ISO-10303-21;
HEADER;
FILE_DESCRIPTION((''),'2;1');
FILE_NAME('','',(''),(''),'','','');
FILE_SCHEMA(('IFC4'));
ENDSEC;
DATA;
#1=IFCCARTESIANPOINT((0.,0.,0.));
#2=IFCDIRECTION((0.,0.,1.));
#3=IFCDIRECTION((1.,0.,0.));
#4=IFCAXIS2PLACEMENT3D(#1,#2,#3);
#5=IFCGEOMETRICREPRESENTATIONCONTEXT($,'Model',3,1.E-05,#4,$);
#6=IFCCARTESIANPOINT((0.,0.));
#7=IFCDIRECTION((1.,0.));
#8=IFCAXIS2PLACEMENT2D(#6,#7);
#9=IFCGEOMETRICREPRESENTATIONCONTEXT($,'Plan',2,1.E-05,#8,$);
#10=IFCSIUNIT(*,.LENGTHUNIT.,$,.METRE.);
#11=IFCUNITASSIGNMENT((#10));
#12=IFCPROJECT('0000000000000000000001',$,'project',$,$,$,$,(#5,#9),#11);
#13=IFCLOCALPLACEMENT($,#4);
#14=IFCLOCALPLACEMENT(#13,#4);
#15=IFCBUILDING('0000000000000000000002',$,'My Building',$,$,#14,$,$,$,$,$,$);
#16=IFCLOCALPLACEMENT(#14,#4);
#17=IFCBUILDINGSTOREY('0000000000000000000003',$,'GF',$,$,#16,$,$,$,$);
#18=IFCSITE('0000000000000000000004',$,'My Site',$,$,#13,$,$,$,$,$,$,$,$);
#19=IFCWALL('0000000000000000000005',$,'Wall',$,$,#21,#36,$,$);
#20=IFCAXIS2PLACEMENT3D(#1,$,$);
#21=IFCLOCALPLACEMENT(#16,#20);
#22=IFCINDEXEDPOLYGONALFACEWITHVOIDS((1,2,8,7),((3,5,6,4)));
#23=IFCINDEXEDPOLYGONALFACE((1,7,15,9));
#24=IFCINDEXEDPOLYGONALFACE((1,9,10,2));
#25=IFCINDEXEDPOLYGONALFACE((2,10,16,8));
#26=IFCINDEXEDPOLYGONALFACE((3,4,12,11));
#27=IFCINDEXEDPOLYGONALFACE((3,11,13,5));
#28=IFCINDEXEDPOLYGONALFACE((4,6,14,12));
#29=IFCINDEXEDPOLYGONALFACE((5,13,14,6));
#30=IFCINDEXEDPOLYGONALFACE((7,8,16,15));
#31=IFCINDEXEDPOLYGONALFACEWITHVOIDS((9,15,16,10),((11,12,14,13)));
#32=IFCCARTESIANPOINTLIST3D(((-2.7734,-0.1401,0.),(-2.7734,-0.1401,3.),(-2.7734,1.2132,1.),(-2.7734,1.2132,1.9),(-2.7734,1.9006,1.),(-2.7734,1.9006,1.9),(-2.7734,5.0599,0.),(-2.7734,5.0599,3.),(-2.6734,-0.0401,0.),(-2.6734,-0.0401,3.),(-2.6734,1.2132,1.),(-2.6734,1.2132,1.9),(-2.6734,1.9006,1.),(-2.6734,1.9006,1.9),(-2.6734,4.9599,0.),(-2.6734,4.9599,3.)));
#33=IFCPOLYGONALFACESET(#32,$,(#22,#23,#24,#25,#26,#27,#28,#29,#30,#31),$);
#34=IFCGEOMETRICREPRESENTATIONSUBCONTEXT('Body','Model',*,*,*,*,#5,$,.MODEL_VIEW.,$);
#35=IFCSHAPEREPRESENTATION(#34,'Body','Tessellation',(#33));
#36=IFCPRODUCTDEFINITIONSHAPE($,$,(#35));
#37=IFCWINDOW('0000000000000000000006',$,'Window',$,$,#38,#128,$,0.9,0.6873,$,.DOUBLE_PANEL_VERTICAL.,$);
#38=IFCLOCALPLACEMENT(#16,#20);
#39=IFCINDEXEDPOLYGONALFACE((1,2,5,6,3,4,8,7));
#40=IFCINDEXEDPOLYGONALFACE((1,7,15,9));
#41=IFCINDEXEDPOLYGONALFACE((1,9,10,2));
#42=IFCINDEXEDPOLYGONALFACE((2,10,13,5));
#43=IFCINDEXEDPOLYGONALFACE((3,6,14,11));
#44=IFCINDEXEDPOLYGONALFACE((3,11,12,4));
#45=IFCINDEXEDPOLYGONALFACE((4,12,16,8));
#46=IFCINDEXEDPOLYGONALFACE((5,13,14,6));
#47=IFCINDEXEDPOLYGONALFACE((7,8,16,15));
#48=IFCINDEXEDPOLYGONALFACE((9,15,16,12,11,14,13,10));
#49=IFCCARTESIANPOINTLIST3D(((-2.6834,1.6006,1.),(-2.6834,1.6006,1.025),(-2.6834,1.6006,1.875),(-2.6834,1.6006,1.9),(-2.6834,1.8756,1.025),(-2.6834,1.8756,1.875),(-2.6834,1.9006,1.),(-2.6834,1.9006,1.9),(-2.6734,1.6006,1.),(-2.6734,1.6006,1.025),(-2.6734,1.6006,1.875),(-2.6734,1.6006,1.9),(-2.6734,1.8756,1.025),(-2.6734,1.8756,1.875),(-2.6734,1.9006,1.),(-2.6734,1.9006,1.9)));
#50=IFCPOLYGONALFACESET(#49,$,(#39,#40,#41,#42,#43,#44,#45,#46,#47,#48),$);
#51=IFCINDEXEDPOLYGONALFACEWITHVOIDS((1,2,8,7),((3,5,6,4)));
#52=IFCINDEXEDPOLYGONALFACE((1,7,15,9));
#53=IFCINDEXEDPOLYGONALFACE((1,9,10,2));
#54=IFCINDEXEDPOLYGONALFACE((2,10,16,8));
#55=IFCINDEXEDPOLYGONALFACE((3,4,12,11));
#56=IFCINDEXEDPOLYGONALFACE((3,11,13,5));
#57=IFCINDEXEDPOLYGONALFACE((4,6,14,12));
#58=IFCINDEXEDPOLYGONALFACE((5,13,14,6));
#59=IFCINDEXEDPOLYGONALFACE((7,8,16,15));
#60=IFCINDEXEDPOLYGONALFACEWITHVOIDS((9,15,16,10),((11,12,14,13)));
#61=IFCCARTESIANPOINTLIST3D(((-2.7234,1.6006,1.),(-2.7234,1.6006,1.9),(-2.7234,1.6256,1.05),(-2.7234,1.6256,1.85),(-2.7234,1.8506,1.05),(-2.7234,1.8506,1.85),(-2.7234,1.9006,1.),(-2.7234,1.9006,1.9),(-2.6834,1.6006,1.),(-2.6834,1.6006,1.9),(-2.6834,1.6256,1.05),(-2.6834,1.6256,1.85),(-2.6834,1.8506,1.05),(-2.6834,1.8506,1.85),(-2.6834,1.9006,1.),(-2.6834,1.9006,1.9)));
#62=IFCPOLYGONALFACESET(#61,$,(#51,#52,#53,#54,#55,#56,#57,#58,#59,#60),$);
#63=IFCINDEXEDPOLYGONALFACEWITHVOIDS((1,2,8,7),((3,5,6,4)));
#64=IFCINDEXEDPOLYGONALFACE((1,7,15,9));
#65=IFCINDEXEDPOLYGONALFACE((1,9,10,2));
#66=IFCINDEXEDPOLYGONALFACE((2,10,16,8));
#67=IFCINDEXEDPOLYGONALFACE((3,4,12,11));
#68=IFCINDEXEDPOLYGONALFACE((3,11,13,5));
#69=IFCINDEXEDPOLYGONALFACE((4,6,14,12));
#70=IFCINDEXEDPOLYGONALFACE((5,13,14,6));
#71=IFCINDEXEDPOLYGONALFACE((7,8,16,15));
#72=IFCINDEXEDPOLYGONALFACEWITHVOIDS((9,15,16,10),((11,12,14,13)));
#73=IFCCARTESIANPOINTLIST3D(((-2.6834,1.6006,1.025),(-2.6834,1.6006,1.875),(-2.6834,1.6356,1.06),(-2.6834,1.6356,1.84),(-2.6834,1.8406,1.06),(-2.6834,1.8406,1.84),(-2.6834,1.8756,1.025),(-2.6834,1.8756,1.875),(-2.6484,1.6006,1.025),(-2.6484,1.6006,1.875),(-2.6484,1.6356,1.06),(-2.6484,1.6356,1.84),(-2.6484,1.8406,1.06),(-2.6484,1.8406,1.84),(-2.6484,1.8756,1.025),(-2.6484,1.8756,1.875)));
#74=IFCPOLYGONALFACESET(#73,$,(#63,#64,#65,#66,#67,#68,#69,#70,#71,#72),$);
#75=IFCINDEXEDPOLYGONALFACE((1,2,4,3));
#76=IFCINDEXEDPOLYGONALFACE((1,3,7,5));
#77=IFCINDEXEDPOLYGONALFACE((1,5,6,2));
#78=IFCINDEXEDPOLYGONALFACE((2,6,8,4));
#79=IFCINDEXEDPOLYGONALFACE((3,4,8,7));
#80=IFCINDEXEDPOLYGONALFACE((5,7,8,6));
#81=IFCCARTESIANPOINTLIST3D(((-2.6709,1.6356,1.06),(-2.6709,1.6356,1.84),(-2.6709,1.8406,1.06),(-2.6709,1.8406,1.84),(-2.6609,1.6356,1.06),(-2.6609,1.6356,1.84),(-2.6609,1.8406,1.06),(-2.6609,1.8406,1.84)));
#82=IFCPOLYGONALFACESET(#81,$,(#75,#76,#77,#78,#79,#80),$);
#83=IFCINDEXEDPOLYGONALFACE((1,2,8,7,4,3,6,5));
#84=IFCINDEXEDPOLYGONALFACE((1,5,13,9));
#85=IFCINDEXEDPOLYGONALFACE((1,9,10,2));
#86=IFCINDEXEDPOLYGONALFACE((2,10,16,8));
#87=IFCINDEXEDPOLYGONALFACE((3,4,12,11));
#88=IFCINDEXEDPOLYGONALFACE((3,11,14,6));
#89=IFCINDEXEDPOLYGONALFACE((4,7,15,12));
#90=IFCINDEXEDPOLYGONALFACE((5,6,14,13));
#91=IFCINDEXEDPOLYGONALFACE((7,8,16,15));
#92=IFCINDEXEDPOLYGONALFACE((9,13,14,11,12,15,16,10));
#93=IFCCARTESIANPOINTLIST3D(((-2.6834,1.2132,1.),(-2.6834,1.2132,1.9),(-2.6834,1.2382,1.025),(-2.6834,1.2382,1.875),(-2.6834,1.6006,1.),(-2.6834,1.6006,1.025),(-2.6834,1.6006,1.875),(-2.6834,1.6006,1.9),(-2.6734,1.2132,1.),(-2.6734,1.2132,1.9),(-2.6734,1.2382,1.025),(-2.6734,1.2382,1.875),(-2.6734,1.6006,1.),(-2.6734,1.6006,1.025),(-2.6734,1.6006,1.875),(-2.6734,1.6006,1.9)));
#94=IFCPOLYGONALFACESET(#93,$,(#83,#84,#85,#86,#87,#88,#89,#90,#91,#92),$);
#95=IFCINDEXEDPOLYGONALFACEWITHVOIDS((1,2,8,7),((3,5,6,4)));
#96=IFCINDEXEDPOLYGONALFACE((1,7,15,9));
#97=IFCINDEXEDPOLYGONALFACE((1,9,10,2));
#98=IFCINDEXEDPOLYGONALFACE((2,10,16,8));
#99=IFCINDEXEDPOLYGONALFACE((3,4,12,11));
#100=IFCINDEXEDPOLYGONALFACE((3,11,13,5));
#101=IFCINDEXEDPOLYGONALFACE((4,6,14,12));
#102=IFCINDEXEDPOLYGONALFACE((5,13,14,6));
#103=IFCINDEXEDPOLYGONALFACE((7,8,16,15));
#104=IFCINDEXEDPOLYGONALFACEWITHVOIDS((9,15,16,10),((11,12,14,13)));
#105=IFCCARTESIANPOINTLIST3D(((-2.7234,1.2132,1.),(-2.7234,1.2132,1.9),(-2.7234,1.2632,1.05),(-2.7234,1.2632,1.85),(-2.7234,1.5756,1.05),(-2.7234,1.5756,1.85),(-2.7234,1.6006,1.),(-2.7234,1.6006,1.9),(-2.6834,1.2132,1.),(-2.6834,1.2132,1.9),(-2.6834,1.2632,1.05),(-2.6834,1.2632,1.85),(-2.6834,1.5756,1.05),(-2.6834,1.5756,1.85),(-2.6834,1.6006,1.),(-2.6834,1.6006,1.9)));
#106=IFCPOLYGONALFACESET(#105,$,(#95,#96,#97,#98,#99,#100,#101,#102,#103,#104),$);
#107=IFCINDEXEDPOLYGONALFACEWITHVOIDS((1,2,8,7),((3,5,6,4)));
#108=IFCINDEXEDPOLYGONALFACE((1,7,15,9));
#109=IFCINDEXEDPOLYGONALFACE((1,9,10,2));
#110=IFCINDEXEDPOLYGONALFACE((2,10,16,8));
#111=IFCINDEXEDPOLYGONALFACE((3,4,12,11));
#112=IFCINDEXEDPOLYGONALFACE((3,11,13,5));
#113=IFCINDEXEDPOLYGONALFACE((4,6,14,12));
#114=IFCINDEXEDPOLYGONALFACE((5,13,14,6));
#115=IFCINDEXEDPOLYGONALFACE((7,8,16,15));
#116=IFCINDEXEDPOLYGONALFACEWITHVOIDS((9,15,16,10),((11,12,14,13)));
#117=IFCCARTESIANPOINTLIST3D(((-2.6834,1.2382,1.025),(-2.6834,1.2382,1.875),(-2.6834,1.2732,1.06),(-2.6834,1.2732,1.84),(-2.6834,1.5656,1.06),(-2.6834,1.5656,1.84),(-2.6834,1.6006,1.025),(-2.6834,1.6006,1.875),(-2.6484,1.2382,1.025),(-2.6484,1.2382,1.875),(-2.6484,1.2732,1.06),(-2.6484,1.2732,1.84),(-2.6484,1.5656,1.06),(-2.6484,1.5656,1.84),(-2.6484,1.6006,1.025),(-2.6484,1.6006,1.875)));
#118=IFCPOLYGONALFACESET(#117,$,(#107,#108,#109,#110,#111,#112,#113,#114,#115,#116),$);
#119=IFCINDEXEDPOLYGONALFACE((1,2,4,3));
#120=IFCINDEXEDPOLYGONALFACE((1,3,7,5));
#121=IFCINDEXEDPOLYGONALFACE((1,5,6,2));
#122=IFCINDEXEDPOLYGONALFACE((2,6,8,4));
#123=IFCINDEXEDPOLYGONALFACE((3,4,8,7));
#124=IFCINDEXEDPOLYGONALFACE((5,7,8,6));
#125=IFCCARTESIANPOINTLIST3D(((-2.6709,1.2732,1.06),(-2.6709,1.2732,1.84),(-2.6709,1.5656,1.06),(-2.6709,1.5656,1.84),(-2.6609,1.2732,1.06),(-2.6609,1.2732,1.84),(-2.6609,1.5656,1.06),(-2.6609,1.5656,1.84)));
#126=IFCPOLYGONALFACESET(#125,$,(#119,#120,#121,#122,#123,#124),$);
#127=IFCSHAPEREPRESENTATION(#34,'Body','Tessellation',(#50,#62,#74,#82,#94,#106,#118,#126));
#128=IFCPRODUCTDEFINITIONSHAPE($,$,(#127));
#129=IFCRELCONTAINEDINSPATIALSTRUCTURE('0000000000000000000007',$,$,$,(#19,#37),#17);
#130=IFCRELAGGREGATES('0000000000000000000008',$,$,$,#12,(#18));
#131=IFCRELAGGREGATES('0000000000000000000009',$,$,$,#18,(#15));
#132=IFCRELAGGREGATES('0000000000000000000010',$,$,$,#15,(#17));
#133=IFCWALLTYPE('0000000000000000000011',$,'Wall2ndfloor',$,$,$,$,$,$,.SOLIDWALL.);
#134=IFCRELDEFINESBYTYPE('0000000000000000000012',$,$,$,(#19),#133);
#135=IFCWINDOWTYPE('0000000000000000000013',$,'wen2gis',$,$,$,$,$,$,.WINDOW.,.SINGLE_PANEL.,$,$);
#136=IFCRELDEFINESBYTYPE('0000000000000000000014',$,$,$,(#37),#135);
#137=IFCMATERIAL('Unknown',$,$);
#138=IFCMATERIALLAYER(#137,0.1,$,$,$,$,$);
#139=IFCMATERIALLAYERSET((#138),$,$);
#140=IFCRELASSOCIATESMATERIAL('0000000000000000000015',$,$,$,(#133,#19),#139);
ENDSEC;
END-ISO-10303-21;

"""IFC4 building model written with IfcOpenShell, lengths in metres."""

from ifc_helpers import new_model, entity, si_unit, frame, origin_with_axes, origin_2d_with_axis, place, context, subcontext, project, spatial, line, indexed_curve, outline, extrude, shape, source, transform, mapped, material, layer, layer_set, layer_usage, type_object, type_shapes, element, fill, save


model = new_model("IFC4")

# Units and contexts
model_context = context("Model", 3, precision=1e-05, world=origin_with_axes())
plan_context = context("Plan", 2, precision=1e-05, world=origin_2d_with_axis())
body_context_1 = subcontext(model_context, "Body", "Model", "MODEL_VIEW")
body_context_2 = subcontext(plan_context, "Body", "Plan", "PLAN_VIEW")
ifc_project = project(units=[si_unit("LENGTHUNIT", "METRE")], contexts=[model_context, plan_context])

# Site, building, storey
site_placement = place(None, origin_with_axes())
site = spatial("IfcSite", under=ifc_project, at=site_placement, Name="My Site")
building_placement = place(site_placement, origin_with_axes())
building = spatial("IfcBuilding", under=site, at=building_placement, Name="My Building")
storey_placement = place(building_placement, origin_with_axes())
storey = spatial("IfcBuildingStorey", under=building, at=storey_placement, Name="GF")

# Shared definitions
ifc_material = material(Name="Unknown")

# Shared definitions
ifc_layer_1 = layer(ifc_material, 0.1)
ifc_layer_set_1 = layer_set([ifc_layer_1])
wall_type = type_object("IfcWallType", Name="Wall2ndfloor", PredefinedType="SOLIDWALL", material=ifc_layer_set_1)

# Wall, opening, window
ifc_layer_usage_1 = layer_usage(ifc_layer_set_1, "AXIS2", "POSITIVE", 0.0)
wall_1_placement = place(storey_placement, frame((-2.7734, 5.0599, 0.0), z_axis=(0.0, 0.0, 1.0), x_axis=(0.0, -1.0, 0.0)))
wall_1 = element("IfcWall", 1, at=wall_1_placement, inside=storey, type_object=wall_type, material=ifc_layer_usage_1, Name="Wall", context=body_context_1, shape_type="SweptSolid", body=[
    extrude(outline(indexed_curve([(0.0, 0.0), (0.1, 0.1), (5.1, 0.1), (5.2, 0.0)], segments=[line(1, 2, 3, 4, 1)])), origin_with_axes(), (0.0, 0.0, 1.0), 3.0),
])
shared_shape_1 = source(origin_with_axes(), body_context_1, "Body", "SweptSolid", [
    extrude(outline(indexed_curve([(0.0, 0.0), (0.6873, 0.0), (0.6873, 0.9), (0.0, 0.9)], segments=[line(1, 2, 3, 4, 1)])), frame((0.0, -0.6, 0.0), z_axis=(0.0, -1.0, 0.0), x_axis=(1.0, 0.0, 0.0)), (0.0, 0.0, -1.0), 1.2),
])
opening_1_placement = place(wall_1_placement, frame((3.1593, 0.0, 1.0), z_axis=(0.0, 0.0, 1.0), x_axis=(1.0, 0.0, 0.0)))
opening_1 = element("IfcOpeningElement", 2, at=opening_1_placement, cuts=wall_1, PredefinedType="OPENING", context=body_context_1, shape_type="MappedRepresentation", body=[
    mapped(shared_shape_1, transform((0.0, 0.0, 0.0), x_axis=(1.0, 0.0, 0.0), y_axis=(0.0, 1.0, 0.0), z_axis=(0.0, 0.0, 1.0), scale=1.0)),
])
window_type_1 = type_object("IfcWindowType", Name="wen2gis", PartitioningType="SINGLE_PANEL", PredefinedType="WINDOW")
shared_shape_2 = source(origin_with_axes(), body_context_1, "Body", "SweptSolid", [
    extrude(outline(indexed_curve([(0.3, 0.0), (0.0, 0.0), (0.0, 0.9), (0.3, 0.9), (0.3, 0.875), (0.025, 0.875), (0.025, 0.025), (0.3, 0.025)], segments=[line(1, 2, 3, 4, 5, 6, 7, 8, 1)])), frame((0.0, 0.09, 0.0), z_axis=(0.0, -1.0, 0.0), x_axis=(1.0, 0.0, 0.0)), (0.0, 0.0, -1.0), 0.01),
    extrude(outline(indexed_curve([(0.0, 0.0), (0.3, 0.0), (0.3, 0.9), (0.0, 0.9)], segments=[line(1, 2, 3, 4, 1)]), holes=[indexed_curve([(0.05, 0.05), (0.275, 0.05), (0.275, 0.85), (0.05, 0.85)], segments=[line(1, 2, 3, 4, 1)])]), frame((0.0, 0.05, 0.0), z_axis=(0.0, -1.0, 0.0), x_axis=(1.0, 0.0, 0.0)), (0.0, 0.0, -1.0), 0.04),
    extrude(outline(indexed_curve([(0.0, 0.0), (0.275, 0.0), (0.275, 0.85), (0.0, 0.85)], segments=[line(1, 2, 3, 4, 1)]), holes=[indexed_curve([(0.035, 0.035), (0.24, 0.035), (0.24, 0.815), (0.035, 0.815)], segments=[line(1, 2, 3, 4, 1)])]), frame((0.025, 0.09, 0.025), z_axis=(0.0, -1.0, 0.0), x_axis=(1.0, 0.0, 0.0)), (0.0, 0.0, -1.0), 0.035),
    extrude(outline(indexed_curve([(0.035, 0.035), (0.24, 0.035), (0.24, 0.815), (0.035, 0.815)], segments=[line(1, 2, 3, 4, 1)])), frame((0.025, 0.1025, 0.025), z_axis=(0.0, -1.0, 0.0), x_axis=(1.0, 0.0, 0.0)), (0.0, 0.0, -1.0), 0.01),
    extrude(outline(indexed_curve([(0.0, 0.9), (0.3873, 0.9), (0.3873, 0.0), (0.0, 0.0), (0.0, 0.025), (0.3623, 0.025), (0.3623, 0.875), (0.0, 0.875)], segments=[line(1, 2, 3, 4, 5, 6, 7, 8, 1)])), frame((0.3, 0.09, 0.0), z_axis=(0.0, -1.0, 0.0), x_axis=(1.0, 0.0, 0.0)), (0.0, 0.0, -1.0), 0.01),
    extrude(outline(indexed_curve([(0.0, 0.0), (0.3873, 0.0), (0.3873, 0.9), (0.0, 0.9)], segments=[line(1, 2, 3, 4, 1)]), holes=[indexed_curve([(0.025, 0.05), (0.3373, 0.05), (0.3373, 0.85), (0.025, 0.85)], segments=[line(1, 2, 3, 4, 1)])]), frame((0.3, 0.05, 0.0), z_axis=(0.0, -1.0, 0.0), x_axis=(1.0, 0.0, 0.0)), (0.0, 0.0, -1.0), 0.04),
    extrude(outline(indexed_curve([(0.0, 0.0), (0.3623, 0.0), (0.3623, 0.85), (0.0, 0.85)], segments=[line(1, 2, 3, 4, 1)]), holes=[indexed_curve([(0.035, 0.035), (0.3273, 0.035), (0.3273, 0.815), (0.035, 0.815)], segments=[line(1, 2, 3, 4, 1)])]), frame((0.3, 0.09, 0.025), z_axis=(0.0, -1.0, 0.0), x_axis=(1.0, 0.0, 0.0)), (0.0, 0.0, -1.0), 0.035),
    extrude(outline(indexed_curve([(0.035, 0.035), (0.3273, 0.035), (0.3273, 0.815), (0.035, 0.815)], segments=[line(1, 2, 3, 4, 1)])), frame((0.3, 0.1025, 0.025), z_axis=(0.0, -1.0, 0.0), x_axis=(1.0, 0.0, 0.0)), (0.0, 0.0, -1.0), 0.01),
])
shared_shape_3 = source(origin_with_axes(), body_context_2, "Body", "Curve2D", [
    entity("IfcIndexedPolyCurve", entity("IfcCartesianPointList2D", [[0.05, 0.05], [0.275, 0.05]])),
    entity("IfcIndexedPolyCurve", entity("IfcCartesianPointList2D", [[0.0, 0.1], [0.025, 0.1], [0.025, 0.09], [0.05, 0.09], [0.05, 0.05], [0.0, 0.05]]), [entity("IfcLineIndex", [1, 2, 3, 4, 5, 6, 1])]),
    entity("IfcIndexedPolyCurve", entity("IfcCartesianPointList2D", [[0.3, 0.1], [0.3, 0.1], [0.3, 0.09], [0.275, 0.09], [0.275, 0.05], [0.3, 0.05]])),
    entity("IfcIndexedPolyCurve", entity("IfcCartesianPointList2D", [[0.025, 0.09], [0.06, 0.09], [0.06, 0.125], [0.025, 0.125]]), [entity("IfcLineIndex", [1, 2, 3, 4, 1])]),
    entity("IfcIndexedPolyCurve", entity("IfcCartesianPointList2D", [[0.3, 0.09], [0.265, 0.09], [0.265, 0.125], [0.3, 0.125]]), [entity("IfcLineIndex", [1, 2, 3, 4, 1])]),
    entity("IfcIndexedPolyCurve", entity("IfcCartesianPointList2D", [[0.06, 0.09], [0.265, 0.09]])),
    entity("IfcIndexedPolyCurve", entity("IfcCartesianPointList2D", [[0.06, 0.125], [0.265, 0.125]])),
    entity("IfcIndexedPolyCurve", entity("IfcCartesianPointList2D", [[0.06, 0.1075], [0.265, 0.1075]])),
    entity("IfcIndexedPolyCurve", entity("IfcCartesianPointList2D", [[0.325, 0.05], [0.6373, 0.05]])),
    entity("IfcIndexedPolyCurve", entity("IfcCartesianPointList2D", [[0.3, 0.1], [0.3, 0.1], [0.3, 0.09], [0.325, 0.09], [0.325, 0.05], [0.3, 0.05]])),
    entity("IfcIndexedPolyCurve", entity("IfcCartesianPointList2D", [[0.6873, 0.1], [0.6623, 0.1], [0.6623, 0.09], [0.6373, 0.09], [0.6373, 0.05], [0.6873, 0.05]]), [entity("IfcLineIndex", [1, 2, 3, 4, 5, 6, 1])]),
    entity("IfcIndexedPolyCurve", entity("IfcCartesianPointList2D", [[0.3, 0.09], [0.335, 0.09], [0.335, 0.125], [0.3, 0.125]]), [entity("IfcLineIndex", [1, 2, 3, 4, 1])]),
    entity("IfcIndexedPolyCurve", entity("IfcCartesianPointList2D", [[0.6623, 0.09], [0.6273, 0.09], [0.6273, 0.125], [0.6623, 0.125]]), [entity("IfcLineIndex", [1, 2, 3, 4, 1])]),
    entity("IfcIndexedPolyCurve", entity("IfcCartesianPointList2D", [[0.335, 0.09], [0.6273, 0.09]])),
    entity("IfcIndexedPolyCurve", entity("IfcCartesianPointList2D", [[0.335, 0.125], [0.6273, 0.125]])),
    entity("IfcIndexedPolyCurve", entity("IfcCartesianPointList2D", [[0.335, 0.1075], [0.6273, 0.1075]])),
])
type_shapes(window_type_1, [shared_shape_2, shared_shape_3])
window_1_placement = place(opening_1_placement, frame((0.0, 0.0, 0.0), z_axis=(0.0, 0.0, 1.0), x_axis=(1.0, 0.0, 0.0)))
window_1 = element("IfcWindow", 3, at=window_1_placement, inside=storey, type_object=window_type_1, Name="Window", OverallHeight=0.9, OverallWidth=0.6873, PartitioningType="DOUBLE_PANEL_VERTICAL", shapes=[
    shape(body_context_1, "Body", "MappedRepresentation", [mapped(shared_shape_2, transform((0.0, 0.0, 0.0), x_axis=(1.0, 0.0, 0.0), y_axis=(0.0, 1.0, 0.0), z_axis=(0.0, 0.0, 1.0), scale=1.0))]),
    shape(body_context_2, "Body", "MappedRepresentation", [mapped(shared_shape_3, transform((0.0, 0.0, 0.0), x_axis=(1.0, 0.0, 0.0), y_axis=(0.0, 1.0, 0.0), z_axis=(0.0, 0.0, 1.0), scale=1.0))]),
])
fill(opening_1, window_1)

save(model, "model.ifc")
